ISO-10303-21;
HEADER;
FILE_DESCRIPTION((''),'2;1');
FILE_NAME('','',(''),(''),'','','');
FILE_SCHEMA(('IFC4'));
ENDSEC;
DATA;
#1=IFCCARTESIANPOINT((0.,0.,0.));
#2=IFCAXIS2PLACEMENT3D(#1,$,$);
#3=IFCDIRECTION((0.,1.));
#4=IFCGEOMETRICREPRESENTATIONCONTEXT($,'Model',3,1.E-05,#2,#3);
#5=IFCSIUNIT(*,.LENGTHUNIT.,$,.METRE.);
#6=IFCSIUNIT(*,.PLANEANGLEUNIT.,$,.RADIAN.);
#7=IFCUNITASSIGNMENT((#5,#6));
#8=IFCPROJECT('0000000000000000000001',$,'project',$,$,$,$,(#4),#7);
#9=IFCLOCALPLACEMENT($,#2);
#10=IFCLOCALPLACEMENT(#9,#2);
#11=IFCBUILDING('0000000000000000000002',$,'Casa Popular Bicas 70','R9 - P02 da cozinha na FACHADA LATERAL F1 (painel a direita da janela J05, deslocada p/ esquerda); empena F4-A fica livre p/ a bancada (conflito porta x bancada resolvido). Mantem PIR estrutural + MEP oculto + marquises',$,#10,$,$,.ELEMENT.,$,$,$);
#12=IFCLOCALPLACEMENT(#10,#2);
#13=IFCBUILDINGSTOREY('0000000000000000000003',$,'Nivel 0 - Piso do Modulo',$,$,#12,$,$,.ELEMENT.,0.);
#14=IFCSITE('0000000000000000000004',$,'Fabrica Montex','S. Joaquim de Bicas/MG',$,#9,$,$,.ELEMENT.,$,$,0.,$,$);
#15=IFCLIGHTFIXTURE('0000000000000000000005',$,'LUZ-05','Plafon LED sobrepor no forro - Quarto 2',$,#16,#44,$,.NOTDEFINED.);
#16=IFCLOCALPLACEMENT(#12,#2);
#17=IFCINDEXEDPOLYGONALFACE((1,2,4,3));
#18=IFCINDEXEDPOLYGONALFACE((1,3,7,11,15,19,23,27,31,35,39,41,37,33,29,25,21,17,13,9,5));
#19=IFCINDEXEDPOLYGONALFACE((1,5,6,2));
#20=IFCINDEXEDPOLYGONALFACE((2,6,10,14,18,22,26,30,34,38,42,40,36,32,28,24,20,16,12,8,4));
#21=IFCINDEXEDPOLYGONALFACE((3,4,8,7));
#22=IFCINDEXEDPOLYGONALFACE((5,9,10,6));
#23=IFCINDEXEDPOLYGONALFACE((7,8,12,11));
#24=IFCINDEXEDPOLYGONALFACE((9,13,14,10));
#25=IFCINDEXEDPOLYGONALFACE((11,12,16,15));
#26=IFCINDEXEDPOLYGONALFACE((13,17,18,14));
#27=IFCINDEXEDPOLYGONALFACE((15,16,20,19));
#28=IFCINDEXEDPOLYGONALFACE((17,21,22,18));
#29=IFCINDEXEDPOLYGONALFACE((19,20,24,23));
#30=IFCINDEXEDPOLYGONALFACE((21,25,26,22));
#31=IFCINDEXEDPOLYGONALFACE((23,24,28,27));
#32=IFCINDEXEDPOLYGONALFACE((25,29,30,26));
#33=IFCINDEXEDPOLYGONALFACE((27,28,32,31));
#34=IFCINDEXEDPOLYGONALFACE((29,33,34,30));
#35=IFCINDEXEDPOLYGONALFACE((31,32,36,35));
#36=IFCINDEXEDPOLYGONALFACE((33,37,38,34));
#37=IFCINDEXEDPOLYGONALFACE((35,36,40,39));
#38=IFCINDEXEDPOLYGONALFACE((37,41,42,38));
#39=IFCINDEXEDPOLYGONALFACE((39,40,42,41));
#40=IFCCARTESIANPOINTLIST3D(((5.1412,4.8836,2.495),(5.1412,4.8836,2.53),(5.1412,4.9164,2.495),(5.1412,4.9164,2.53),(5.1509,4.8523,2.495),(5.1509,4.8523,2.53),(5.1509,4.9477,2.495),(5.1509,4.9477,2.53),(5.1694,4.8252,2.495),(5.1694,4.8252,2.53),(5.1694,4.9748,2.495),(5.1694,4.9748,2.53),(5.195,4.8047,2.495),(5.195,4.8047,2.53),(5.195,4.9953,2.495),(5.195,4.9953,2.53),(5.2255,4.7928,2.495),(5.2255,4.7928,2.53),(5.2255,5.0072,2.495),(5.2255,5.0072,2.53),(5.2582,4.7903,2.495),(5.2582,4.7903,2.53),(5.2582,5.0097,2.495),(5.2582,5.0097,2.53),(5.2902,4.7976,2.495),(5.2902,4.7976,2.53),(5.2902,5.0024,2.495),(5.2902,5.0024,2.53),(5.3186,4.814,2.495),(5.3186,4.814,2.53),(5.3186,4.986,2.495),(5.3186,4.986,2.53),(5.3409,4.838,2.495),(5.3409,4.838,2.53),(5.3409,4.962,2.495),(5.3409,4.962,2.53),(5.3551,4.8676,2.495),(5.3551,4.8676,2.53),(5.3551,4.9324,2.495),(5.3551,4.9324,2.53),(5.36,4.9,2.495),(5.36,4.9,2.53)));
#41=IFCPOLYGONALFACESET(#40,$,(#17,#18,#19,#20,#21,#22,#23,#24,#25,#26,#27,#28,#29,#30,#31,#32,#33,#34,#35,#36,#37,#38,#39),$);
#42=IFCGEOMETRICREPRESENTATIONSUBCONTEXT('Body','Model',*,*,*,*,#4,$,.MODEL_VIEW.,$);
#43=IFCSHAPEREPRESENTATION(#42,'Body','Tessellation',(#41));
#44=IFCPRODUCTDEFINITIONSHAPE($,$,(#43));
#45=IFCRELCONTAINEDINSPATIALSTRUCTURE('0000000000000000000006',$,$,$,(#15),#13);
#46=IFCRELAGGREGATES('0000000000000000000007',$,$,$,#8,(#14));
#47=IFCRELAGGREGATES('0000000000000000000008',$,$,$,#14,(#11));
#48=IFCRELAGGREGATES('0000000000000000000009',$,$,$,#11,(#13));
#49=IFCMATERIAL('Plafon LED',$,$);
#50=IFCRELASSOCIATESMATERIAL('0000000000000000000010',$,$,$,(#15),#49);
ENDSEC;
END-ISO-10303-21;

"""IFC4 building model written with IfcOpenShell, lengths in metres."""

from ifc_helpers import new_model, si_unit, direction, frame, origin, origin_2d, place, context, subcontext, project, spatial, circle, extrude, material, element, save


model = new_model("IFC4")

# Units and contexts
model_context_1 = context("Model", 3, precision=1e-05, world=origin(), true_north=direction((0.0, 1.0)))
body_context_1 = subcontext(model_context_1, "Body", "Model", "MODEL_VIEW")
ifc_project = project(units=[si_unit("LENGTHUNIT", "METRE"), si_unit("PLANEANGLEUNIT", "RADIAN")], contexts=[model_context_1])

# Site, building, storey
site_placement = place(None, origin())
site = spatial("IfcSite", under=ifc_project, at=site_placement, Name="Fabrica Montex", Description="S. Joaquim de Bicas/MG", CompositionType="ELEMENT", RefElevation=0.0)
building_placement = place(site_placement, origin())
building = spatial("IfcBuilding", under=site, at=building_placement, Name="Casa Popular Bicas 70", Description="R9 - P02 da cozinha na FACHADA LATERAL F1 (painel a direita da janela J05, deslocada p/ esquerda); empena F4-A fica livre p/ a bancada (conflito porta x bancada resolvido). Mantem PIR estrutural + MEP oculto + marquises", CompositionType="ELEMENT")
storey_placement = place(building_placement, origin())
storey = spatial("IfcBuildingStorey", under=building, at=storey_placement, Name="Nivel 0 - Piso do Modulo", CompositionType="ELEMENT", Elevation=0.0)

# Light fixture
ifc_material_1 = material(Name="Plafon LED")
light_fixture_placement = place(storey_placement, frame((5.25, 4.9, 2.495)))
element("IfcLightFixture", 1, at=light_fixture_placement, inside=storey, material=ifc_material_1, Name="LUZ-05", Description="Plafon LED sobrepor no forro - Quarto 2", PredefinedType="NOTDEFINED", context=body_context_1, shape_type="SweptSolid", body=[
    extrude(circle(Radius=0.11, at=origin_2d()), origin(), (0.0, 0.0, 1.0), 0.035),
])

save(model, "model.ifc")
